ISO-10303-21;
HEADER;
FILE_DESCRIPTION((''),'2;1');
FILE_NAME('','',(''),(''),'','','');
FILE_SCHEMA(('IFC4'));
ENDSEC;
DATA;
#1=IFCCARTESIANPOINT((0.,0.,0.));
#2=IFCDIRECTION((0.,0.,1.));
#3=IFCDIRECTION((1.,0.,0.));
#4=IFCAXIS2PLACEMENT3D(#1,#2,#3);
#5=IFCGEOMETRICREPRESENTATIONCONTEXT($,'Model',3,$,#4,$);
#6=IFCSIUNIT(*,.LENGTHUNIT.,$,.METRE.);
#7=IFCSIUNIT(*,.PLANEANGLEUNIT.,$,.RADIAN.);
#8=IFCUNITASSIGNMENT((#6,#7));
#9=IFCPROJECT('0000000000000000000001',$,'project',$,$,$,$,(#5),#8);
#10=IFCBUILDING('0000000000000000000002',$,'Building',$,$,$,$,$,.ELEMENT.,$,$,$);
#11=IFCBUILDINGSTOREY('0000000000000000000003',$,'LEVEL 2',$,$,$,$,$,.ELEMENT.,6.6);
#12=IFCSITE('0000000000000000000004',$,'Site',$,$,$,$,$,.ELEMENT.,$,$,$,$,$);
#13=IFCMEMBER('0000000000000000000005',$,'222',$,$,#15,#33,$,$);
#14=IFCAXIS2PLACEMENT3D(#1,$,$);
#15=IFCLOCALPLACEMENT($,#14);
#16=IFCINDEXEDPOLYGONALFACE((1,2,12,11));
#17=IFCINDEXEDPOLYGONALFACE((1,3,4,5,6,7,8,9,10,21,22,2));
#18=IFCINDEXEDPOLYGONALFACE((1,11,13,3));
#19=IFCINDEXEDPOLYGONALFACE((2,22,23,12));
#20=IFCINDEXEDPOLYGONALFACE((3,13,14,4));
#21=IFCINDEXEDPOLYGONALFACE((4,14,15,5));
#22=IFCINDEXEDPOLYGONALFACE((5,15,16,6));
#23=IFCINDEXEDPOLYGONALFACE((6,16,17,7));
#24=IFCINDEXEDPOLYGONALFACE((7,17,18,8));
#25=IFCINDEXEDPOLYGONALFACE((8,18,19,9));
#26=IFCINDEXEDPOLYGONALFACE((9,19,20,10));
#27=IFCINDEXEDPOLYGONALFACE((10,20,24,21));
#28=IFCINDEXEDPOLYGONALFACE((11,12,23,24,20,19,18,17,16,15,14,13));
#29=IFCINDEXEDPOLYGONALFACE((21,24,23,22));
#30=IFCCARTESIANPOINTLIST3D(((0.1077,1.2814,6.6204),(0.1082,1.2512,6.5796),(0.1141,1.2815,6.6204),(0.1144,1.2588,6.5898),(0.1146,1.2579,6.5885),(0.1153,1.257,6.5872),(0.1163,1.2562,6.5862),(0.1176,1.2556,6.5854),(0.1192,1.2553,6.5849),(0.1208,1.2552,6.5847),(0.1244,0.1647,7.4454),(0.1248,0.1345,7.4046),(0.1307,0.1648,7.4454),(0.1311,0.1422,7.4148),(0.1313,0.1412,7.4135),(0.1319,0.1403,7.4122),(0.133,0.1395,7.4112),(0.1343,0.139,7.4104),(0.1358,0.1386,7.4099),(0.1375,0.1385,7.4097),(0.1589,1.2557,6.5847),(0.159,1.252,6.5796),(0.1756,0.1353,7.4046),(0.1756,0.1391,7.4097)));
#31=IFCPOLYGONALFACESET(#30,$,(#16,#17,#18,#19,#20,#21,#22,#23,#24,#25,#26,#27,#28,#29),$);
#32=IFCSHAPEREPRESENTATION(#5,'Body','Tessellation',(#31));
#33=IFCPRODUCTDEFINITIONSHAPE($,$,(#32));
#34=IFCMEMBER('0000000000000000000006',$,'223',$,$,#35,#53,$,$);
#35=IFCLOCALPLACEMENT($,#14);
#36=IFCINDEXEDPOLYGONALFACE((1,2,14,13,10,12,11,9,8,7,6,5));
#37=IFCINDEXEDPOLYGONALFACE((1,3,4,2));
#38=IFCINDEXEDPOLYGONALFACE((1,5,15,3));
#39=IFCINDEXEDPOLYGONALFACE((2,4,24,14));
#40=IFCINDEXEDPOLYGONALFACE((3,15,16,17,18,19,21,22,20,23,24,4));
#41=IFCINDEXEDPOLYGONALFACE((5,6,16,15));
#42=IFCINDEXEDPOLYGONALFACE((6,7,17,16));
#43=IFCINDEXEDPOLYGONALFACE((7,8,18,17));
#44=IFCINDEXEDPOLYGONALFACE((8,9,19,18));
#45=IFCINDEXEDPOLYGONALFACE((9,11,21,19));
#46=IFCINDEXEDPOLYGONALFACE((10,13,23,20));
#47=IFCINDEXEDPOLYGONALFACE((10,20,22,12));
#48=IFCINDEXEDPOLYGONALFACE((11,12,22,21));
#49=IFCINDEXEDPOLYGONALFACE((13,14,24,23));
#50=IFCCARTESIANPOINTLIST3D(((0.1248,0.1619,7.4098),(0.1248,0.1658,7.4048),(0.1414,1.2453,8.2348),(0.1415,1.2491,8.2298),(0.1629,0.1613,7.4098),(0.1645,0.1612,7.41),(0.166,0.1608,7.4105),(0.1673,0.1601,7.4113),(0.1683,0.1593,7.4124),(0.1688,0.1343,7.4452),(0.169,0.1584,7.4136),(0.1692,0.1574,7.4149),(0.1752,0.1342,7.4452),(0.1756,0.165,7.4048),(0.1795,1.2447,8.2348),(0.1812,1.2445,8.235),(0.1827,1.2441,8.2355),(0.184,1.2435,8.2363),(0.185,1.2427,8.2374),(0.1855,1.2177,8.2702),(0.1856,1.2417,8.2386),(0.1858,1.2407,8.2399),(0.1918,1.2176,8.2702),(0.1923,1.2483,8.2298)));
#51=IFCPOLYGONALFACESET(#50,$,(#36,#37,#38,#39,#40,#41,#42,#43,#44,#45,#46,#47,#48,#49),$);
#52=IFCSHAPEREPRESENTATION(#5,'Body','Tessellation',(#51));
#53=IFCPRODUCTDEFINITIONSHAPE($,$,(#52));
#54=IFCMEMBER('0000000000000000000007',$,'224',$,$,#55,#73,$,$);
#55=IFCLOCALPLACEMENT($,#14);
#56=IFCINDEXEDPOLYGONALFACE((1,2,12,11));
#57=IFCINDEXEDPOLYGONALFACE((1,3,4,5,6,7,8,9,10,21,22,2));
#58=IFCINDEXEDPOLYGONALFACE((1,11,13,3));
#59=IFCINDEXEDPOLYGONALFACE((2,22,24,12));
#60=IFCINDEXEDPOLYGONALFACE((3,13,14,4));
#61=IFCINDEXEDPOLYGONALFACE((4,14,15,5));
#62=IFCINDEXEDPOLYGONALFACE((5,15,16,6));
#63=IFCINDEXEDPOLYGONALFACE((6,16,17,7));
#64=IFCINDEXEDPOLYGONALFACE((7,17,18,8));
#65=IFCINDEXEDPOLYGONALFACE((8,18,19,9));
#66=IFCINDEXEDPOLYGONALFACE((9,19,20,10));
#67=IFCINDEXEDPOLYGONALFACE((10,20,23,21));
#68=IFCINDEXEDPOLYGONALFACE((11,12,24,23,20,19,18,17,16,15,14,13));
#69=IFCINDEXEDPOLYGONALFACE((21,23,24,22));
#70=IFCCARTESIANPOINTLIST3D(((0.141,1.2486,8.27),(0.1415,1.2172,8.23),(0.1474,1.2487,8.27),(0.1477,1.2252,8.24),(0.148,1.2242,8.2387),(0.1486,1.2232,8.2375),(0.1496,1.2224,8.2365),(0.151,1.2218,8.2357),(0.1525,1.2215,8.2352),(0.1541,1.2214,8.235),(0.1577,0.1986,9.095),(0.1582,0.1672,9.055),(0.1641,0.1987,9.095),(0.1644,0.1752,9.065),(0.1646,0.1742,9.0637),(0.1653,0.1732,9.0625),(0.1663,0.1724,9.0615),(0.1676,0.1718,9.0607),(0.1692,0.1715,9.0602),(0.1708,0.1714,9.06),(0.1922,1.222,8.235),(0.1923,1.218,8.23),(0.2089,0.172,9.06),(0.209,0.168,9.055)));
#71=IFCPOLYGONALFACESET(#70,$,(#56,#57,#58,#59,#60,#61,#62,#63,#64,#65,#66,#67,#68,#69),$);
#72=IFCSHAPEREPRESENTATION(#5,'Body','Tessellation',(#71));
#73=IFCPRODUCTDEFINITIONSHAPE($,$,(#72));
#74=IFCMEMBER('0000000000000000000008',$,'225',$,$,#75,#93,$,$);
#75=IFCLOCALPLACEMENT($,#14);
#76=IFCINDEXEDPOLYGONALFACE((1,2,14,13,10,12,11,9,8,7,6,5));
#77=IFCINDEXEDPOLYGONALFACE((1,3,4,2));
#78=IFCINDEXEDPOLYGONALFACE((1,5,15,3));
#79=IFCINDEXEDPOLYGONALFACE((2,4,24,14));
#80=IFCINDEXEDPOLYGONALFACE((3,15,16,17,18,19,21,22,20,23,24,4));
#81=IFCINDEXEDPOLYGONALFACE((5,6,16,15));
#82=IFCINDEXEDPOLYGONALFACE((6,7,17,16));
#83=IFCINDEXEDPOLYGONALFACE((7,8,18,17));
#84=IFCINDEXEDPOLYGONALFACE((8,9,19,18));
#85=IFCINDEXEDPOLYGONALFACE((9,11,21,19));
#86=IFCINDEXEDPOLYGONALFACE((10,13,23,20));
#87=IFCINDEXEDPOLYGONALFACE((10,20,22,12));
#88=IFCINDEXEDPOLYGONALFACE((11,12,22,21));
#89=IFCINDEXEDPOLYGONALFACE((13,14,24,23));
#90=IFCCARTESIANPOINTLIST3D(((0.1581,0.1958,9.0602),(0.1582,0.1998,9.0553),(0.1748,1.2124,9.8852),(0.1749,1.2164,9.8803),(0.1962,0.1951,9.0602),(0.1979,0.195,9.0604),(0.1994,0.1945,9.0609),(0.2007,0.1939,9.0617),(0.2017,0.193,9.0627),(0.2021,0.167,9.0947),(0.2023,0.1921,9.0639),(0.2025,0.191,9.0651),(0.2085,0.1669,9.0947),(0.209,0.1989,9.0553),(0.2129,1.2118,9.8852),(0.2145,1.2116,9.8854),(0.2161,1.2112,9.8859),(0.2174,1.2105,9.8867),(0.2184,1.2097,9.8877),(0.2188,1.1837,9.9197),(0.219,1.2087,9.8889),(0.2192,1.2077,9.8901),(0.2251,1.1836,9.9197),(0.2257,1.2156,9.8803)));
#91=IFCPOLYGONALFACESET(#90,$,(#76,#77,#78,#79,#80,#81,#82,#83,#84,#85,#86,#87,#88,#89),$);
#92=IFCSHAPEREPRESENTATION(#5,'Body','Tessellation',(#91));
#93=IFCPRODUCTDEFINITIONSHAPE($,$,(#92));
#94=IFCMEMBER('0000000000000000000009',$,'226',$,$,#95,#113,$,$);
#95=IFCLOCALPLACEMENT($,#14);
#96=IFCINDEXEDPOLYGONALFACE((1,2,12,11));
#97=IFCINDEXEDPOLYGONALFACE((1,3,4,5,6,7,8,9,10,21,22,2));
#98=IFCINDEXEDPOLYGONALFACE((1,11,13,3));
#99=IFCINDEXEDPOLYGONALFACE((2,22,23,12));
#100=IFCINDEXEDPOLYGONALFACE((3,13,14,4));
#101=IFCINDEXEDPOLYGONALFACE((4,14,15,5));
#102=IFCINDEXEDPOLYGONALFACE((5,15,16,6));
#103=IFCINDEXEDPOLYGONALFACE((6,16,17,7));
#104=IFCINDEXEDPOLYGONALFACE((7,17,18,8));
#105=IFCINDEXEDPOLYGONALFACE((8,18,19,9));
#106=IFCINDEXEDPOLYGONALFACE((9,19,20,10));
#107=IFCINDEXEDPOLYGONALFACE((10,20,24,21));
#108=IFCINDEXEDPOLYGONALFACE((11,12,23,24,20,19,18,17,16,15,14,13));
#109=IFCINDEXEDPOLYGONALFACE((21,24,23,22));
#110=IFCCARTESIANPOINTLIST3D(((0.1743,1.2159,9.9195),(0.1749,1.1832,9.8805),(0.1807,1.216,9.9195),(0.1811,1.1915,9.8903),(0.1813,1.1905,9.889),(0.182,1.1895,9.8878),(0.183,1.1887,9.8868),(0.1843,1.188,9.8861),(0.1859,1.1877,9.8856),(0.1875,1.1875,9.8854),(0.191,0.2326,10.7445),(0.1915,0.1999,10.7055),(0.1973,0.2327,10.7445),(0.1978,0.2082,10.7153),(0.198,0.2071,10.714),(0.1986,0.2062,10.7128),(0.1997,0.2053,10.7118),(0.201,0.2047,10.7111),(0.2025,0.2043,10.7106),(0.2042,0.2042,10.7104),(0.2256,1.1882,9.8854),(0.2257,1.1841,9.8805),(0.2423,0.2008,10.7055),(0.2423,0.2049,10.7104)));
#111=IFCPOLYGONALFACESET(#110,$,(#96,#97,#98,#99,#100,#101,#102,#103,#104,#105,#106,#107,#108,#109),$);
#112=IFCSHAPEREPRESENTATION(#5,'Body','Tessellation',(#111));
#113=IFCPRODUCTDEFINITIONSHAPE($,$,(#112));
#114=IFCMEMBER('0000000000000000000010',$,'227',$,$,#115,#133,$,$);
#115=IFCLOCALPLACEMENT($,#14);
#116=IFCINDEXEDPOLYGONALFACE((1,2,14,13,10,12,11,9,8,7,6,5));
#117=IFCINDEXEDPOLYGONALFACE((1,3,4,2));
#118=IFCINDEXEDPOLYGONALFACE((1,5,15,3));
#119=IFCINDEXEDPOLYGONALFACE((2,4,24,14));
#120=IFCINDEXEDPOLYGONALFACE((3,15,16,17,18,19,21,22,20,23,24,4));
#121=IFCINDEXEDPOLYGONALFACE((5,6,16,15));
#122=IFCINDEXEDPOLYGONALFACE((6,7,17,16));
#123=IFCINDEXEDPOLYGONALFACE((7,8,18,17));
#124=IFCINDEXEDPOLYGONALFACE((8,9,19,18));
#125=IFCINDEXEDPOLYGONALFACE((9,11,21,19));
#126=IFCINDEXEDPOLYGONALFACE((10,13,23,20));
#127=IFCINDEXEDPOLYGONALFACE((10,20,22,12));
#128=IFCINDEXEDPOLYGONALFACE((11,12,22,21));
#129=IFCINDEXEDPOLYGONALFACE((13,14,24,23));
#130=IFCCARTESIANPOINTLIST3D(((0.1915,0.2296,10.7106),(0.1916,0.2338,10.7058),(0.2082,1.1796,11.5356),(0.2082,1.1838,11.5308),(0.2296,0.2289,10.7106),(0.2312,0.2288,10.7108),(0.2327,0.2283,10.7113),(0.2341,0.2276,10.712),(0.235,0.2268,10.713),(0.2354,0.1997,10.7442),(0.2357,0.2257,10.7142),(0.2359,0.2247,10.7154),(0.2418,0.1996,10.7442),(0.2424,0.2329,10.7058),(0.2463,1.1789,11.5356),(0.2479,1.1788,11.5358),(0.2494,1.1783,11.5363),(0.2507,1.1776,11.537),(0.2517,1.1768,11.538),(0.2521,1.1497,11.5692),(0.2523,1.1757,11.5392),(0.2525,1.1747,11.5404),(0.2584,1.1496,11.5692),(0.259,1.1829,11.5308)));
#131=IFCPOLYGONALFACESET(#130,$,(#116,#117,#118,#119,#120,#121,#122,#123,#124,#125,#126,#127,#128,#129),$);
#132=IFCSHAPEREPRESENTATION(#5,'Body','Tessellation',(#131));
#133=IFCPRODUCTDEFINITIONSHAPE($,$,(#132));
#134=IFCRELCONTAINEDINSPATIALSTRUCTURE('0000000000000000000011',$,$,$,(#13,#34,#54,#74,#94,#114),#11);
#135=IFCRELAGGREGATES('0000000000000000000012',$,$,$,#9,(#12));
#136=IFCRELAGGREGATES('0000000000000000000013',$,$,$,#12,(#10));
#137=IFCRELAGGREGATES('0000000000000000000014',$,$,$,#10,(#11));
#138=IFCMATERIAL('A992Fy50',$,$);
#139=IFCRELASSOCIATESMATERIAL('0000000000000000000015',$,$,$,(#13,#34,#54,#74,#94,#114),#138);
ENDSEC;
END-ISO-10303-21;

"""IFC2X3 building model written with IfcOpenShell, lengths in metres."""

from ifc_helpers import new_model, si_unit, frame, origin_with_axes, origin_2d_with_axis, place, context, project, spatial, l_section, extrude, material, element, save


model = new_model("IFC2X3")

# Units and contexts
model_context = context("Model", 3, world=origin_with_axes())
ifc_project = project(units=[si_unit("LENGTHUNIT", "METRE"), si_unit("PLANEANGLEUNIT", "RADIAN")], contexts=[model_context])

# Site, building, storey
site = spatial("IfcSite", under=ifc_project, Name="Site", CompositionType="ELEMENT")
building = spatial("IfcBuilding", under=site, Name="Building", CompositionType="ELEMENT")
storey = spatial("IfcBuildingStorey", under=building, Name="LEVEL 2", CompositionType="ELEMENT", Elevation=6.6)

# Shared definitions
ifc_material = material(Name="A992Fy50")

# Members
member_1_placement = place(None, frame((0.1333, 1.2667, 6.6), z_axis=(0.012004, -0.804243, 0.594179), x_axis=(0.999889, 0.014924, 0.0)))
element("IfcMember", 1, at=member_1_placement, inside=storey, material=ifc_material, Name="222", context=model_context, shape_type="SweptSolid", body=[
    extrude(l_section(Depth=0.0508, Width=0.0508, Thickness=0.0063, FilletRadius=0.0063, at=origin_2d_with_axis()), origin_with_axes(), (0.0, 0.0, 1.0), 1.3885),
])
member_2_placement = place(None, frame((0.15, 0.15, 7.425), z_axis=(0.012239, 0.795513, 0.605813), x_axis=(-0.999882, 0.015383, 0.0)))
element("IfcMember", 2, at=member_2_placement, inside=storey, material=ifc_material, Name="223", context=model_context, shape_type="SweptSolid", body=[
    extrude(l_section(Depth=0.0508, Width=0.0508, Thickness=0.0063, FilletRadius=0.0063, at=origin_2d_with_axis()), origin_with_axes(), (0.0, 0.0, 1.0), 1.3618),
])
member_3_placement = place(None, frame((0.1667, 1.2333, 8.25), z_axis=(0.01248, -0.786257, 0.617773), x_axis=(0.999889, 0.014924, 0.0)))
element("IfcMember", 3, at=member_3_placement, inside=storey, material=ifc_material, Name="224", context=model_context, shape_type="SweptSolid", body=[
    extrude(l_section(Depth=0.0508, Width=0.0508, Thickness=0.0063, FilletRadius=0.0063, at=origin_2d_with_axis()), origin_with_axes(), (0.0, 0.0, 1.0), 1.3354),
])
member_4_placement = place(None, frame((0.1833, 0.1833, 9.075), z_axis=(0.012729, 0.77644, 0.630062), x_axis=(-0.999866, 0.016391, 0.0)))
element("IfcMember", 4, at=member_4_placement, inside=storey, material=ifc_material, Name="225", context=model_context, shape_type="SweptSolid", body=[
    extrude(l_section(Depth=0.0508, Width=0.0508, Thickness=0.0063, FilletRadius=0.0063, at=origin_2d_with_axis()), origin_with_axes(), (0.0, 0.0, 1.0), 1.3094),
])
member_5_placement = place(None, frame((0.2, 1.2, 9.9), z_axis=(0.012983, -0.766024, 0.642681), x_axis=(0.999856, 0.016947, 0.0)))
element("IfcMember", 5, at=member_5_placement, inside=storey, material=ifc_material, Name="226", context=model_context, shape_type="SweptSolid", body=[
    extrude(l_section(Depth=0.0508, Width=0.0508, Thickness=0.0063, FilletRadius=0.0063, at=origin_2d_with_axis()), origin_with_axes(), (0.0, 0.0, 1.0), 1.2837),
])
member_6_placement = place(None, frame((0.2167, 0.2167, 10.725), z_axis=(0.013245, 0.754967, 0.655629), x_axis=(-0.999846, 0.017541, 0.0)))
element("IfcMember", 6, at=member_6_placement, inside=storey, material=ifc_material, Name="227", context=model_context, shape_type="SweptSolid", body=[
    extrude(l_section(Depth=0.0508, Width=0.0508, Thickness=0.0063, FilletRadius=0.0063, at=origin_2d_with_axis()), origin_with_axes(), (0.0, 0.0, 1.0), 1.2583),
])

save(model, "model.ifc")
